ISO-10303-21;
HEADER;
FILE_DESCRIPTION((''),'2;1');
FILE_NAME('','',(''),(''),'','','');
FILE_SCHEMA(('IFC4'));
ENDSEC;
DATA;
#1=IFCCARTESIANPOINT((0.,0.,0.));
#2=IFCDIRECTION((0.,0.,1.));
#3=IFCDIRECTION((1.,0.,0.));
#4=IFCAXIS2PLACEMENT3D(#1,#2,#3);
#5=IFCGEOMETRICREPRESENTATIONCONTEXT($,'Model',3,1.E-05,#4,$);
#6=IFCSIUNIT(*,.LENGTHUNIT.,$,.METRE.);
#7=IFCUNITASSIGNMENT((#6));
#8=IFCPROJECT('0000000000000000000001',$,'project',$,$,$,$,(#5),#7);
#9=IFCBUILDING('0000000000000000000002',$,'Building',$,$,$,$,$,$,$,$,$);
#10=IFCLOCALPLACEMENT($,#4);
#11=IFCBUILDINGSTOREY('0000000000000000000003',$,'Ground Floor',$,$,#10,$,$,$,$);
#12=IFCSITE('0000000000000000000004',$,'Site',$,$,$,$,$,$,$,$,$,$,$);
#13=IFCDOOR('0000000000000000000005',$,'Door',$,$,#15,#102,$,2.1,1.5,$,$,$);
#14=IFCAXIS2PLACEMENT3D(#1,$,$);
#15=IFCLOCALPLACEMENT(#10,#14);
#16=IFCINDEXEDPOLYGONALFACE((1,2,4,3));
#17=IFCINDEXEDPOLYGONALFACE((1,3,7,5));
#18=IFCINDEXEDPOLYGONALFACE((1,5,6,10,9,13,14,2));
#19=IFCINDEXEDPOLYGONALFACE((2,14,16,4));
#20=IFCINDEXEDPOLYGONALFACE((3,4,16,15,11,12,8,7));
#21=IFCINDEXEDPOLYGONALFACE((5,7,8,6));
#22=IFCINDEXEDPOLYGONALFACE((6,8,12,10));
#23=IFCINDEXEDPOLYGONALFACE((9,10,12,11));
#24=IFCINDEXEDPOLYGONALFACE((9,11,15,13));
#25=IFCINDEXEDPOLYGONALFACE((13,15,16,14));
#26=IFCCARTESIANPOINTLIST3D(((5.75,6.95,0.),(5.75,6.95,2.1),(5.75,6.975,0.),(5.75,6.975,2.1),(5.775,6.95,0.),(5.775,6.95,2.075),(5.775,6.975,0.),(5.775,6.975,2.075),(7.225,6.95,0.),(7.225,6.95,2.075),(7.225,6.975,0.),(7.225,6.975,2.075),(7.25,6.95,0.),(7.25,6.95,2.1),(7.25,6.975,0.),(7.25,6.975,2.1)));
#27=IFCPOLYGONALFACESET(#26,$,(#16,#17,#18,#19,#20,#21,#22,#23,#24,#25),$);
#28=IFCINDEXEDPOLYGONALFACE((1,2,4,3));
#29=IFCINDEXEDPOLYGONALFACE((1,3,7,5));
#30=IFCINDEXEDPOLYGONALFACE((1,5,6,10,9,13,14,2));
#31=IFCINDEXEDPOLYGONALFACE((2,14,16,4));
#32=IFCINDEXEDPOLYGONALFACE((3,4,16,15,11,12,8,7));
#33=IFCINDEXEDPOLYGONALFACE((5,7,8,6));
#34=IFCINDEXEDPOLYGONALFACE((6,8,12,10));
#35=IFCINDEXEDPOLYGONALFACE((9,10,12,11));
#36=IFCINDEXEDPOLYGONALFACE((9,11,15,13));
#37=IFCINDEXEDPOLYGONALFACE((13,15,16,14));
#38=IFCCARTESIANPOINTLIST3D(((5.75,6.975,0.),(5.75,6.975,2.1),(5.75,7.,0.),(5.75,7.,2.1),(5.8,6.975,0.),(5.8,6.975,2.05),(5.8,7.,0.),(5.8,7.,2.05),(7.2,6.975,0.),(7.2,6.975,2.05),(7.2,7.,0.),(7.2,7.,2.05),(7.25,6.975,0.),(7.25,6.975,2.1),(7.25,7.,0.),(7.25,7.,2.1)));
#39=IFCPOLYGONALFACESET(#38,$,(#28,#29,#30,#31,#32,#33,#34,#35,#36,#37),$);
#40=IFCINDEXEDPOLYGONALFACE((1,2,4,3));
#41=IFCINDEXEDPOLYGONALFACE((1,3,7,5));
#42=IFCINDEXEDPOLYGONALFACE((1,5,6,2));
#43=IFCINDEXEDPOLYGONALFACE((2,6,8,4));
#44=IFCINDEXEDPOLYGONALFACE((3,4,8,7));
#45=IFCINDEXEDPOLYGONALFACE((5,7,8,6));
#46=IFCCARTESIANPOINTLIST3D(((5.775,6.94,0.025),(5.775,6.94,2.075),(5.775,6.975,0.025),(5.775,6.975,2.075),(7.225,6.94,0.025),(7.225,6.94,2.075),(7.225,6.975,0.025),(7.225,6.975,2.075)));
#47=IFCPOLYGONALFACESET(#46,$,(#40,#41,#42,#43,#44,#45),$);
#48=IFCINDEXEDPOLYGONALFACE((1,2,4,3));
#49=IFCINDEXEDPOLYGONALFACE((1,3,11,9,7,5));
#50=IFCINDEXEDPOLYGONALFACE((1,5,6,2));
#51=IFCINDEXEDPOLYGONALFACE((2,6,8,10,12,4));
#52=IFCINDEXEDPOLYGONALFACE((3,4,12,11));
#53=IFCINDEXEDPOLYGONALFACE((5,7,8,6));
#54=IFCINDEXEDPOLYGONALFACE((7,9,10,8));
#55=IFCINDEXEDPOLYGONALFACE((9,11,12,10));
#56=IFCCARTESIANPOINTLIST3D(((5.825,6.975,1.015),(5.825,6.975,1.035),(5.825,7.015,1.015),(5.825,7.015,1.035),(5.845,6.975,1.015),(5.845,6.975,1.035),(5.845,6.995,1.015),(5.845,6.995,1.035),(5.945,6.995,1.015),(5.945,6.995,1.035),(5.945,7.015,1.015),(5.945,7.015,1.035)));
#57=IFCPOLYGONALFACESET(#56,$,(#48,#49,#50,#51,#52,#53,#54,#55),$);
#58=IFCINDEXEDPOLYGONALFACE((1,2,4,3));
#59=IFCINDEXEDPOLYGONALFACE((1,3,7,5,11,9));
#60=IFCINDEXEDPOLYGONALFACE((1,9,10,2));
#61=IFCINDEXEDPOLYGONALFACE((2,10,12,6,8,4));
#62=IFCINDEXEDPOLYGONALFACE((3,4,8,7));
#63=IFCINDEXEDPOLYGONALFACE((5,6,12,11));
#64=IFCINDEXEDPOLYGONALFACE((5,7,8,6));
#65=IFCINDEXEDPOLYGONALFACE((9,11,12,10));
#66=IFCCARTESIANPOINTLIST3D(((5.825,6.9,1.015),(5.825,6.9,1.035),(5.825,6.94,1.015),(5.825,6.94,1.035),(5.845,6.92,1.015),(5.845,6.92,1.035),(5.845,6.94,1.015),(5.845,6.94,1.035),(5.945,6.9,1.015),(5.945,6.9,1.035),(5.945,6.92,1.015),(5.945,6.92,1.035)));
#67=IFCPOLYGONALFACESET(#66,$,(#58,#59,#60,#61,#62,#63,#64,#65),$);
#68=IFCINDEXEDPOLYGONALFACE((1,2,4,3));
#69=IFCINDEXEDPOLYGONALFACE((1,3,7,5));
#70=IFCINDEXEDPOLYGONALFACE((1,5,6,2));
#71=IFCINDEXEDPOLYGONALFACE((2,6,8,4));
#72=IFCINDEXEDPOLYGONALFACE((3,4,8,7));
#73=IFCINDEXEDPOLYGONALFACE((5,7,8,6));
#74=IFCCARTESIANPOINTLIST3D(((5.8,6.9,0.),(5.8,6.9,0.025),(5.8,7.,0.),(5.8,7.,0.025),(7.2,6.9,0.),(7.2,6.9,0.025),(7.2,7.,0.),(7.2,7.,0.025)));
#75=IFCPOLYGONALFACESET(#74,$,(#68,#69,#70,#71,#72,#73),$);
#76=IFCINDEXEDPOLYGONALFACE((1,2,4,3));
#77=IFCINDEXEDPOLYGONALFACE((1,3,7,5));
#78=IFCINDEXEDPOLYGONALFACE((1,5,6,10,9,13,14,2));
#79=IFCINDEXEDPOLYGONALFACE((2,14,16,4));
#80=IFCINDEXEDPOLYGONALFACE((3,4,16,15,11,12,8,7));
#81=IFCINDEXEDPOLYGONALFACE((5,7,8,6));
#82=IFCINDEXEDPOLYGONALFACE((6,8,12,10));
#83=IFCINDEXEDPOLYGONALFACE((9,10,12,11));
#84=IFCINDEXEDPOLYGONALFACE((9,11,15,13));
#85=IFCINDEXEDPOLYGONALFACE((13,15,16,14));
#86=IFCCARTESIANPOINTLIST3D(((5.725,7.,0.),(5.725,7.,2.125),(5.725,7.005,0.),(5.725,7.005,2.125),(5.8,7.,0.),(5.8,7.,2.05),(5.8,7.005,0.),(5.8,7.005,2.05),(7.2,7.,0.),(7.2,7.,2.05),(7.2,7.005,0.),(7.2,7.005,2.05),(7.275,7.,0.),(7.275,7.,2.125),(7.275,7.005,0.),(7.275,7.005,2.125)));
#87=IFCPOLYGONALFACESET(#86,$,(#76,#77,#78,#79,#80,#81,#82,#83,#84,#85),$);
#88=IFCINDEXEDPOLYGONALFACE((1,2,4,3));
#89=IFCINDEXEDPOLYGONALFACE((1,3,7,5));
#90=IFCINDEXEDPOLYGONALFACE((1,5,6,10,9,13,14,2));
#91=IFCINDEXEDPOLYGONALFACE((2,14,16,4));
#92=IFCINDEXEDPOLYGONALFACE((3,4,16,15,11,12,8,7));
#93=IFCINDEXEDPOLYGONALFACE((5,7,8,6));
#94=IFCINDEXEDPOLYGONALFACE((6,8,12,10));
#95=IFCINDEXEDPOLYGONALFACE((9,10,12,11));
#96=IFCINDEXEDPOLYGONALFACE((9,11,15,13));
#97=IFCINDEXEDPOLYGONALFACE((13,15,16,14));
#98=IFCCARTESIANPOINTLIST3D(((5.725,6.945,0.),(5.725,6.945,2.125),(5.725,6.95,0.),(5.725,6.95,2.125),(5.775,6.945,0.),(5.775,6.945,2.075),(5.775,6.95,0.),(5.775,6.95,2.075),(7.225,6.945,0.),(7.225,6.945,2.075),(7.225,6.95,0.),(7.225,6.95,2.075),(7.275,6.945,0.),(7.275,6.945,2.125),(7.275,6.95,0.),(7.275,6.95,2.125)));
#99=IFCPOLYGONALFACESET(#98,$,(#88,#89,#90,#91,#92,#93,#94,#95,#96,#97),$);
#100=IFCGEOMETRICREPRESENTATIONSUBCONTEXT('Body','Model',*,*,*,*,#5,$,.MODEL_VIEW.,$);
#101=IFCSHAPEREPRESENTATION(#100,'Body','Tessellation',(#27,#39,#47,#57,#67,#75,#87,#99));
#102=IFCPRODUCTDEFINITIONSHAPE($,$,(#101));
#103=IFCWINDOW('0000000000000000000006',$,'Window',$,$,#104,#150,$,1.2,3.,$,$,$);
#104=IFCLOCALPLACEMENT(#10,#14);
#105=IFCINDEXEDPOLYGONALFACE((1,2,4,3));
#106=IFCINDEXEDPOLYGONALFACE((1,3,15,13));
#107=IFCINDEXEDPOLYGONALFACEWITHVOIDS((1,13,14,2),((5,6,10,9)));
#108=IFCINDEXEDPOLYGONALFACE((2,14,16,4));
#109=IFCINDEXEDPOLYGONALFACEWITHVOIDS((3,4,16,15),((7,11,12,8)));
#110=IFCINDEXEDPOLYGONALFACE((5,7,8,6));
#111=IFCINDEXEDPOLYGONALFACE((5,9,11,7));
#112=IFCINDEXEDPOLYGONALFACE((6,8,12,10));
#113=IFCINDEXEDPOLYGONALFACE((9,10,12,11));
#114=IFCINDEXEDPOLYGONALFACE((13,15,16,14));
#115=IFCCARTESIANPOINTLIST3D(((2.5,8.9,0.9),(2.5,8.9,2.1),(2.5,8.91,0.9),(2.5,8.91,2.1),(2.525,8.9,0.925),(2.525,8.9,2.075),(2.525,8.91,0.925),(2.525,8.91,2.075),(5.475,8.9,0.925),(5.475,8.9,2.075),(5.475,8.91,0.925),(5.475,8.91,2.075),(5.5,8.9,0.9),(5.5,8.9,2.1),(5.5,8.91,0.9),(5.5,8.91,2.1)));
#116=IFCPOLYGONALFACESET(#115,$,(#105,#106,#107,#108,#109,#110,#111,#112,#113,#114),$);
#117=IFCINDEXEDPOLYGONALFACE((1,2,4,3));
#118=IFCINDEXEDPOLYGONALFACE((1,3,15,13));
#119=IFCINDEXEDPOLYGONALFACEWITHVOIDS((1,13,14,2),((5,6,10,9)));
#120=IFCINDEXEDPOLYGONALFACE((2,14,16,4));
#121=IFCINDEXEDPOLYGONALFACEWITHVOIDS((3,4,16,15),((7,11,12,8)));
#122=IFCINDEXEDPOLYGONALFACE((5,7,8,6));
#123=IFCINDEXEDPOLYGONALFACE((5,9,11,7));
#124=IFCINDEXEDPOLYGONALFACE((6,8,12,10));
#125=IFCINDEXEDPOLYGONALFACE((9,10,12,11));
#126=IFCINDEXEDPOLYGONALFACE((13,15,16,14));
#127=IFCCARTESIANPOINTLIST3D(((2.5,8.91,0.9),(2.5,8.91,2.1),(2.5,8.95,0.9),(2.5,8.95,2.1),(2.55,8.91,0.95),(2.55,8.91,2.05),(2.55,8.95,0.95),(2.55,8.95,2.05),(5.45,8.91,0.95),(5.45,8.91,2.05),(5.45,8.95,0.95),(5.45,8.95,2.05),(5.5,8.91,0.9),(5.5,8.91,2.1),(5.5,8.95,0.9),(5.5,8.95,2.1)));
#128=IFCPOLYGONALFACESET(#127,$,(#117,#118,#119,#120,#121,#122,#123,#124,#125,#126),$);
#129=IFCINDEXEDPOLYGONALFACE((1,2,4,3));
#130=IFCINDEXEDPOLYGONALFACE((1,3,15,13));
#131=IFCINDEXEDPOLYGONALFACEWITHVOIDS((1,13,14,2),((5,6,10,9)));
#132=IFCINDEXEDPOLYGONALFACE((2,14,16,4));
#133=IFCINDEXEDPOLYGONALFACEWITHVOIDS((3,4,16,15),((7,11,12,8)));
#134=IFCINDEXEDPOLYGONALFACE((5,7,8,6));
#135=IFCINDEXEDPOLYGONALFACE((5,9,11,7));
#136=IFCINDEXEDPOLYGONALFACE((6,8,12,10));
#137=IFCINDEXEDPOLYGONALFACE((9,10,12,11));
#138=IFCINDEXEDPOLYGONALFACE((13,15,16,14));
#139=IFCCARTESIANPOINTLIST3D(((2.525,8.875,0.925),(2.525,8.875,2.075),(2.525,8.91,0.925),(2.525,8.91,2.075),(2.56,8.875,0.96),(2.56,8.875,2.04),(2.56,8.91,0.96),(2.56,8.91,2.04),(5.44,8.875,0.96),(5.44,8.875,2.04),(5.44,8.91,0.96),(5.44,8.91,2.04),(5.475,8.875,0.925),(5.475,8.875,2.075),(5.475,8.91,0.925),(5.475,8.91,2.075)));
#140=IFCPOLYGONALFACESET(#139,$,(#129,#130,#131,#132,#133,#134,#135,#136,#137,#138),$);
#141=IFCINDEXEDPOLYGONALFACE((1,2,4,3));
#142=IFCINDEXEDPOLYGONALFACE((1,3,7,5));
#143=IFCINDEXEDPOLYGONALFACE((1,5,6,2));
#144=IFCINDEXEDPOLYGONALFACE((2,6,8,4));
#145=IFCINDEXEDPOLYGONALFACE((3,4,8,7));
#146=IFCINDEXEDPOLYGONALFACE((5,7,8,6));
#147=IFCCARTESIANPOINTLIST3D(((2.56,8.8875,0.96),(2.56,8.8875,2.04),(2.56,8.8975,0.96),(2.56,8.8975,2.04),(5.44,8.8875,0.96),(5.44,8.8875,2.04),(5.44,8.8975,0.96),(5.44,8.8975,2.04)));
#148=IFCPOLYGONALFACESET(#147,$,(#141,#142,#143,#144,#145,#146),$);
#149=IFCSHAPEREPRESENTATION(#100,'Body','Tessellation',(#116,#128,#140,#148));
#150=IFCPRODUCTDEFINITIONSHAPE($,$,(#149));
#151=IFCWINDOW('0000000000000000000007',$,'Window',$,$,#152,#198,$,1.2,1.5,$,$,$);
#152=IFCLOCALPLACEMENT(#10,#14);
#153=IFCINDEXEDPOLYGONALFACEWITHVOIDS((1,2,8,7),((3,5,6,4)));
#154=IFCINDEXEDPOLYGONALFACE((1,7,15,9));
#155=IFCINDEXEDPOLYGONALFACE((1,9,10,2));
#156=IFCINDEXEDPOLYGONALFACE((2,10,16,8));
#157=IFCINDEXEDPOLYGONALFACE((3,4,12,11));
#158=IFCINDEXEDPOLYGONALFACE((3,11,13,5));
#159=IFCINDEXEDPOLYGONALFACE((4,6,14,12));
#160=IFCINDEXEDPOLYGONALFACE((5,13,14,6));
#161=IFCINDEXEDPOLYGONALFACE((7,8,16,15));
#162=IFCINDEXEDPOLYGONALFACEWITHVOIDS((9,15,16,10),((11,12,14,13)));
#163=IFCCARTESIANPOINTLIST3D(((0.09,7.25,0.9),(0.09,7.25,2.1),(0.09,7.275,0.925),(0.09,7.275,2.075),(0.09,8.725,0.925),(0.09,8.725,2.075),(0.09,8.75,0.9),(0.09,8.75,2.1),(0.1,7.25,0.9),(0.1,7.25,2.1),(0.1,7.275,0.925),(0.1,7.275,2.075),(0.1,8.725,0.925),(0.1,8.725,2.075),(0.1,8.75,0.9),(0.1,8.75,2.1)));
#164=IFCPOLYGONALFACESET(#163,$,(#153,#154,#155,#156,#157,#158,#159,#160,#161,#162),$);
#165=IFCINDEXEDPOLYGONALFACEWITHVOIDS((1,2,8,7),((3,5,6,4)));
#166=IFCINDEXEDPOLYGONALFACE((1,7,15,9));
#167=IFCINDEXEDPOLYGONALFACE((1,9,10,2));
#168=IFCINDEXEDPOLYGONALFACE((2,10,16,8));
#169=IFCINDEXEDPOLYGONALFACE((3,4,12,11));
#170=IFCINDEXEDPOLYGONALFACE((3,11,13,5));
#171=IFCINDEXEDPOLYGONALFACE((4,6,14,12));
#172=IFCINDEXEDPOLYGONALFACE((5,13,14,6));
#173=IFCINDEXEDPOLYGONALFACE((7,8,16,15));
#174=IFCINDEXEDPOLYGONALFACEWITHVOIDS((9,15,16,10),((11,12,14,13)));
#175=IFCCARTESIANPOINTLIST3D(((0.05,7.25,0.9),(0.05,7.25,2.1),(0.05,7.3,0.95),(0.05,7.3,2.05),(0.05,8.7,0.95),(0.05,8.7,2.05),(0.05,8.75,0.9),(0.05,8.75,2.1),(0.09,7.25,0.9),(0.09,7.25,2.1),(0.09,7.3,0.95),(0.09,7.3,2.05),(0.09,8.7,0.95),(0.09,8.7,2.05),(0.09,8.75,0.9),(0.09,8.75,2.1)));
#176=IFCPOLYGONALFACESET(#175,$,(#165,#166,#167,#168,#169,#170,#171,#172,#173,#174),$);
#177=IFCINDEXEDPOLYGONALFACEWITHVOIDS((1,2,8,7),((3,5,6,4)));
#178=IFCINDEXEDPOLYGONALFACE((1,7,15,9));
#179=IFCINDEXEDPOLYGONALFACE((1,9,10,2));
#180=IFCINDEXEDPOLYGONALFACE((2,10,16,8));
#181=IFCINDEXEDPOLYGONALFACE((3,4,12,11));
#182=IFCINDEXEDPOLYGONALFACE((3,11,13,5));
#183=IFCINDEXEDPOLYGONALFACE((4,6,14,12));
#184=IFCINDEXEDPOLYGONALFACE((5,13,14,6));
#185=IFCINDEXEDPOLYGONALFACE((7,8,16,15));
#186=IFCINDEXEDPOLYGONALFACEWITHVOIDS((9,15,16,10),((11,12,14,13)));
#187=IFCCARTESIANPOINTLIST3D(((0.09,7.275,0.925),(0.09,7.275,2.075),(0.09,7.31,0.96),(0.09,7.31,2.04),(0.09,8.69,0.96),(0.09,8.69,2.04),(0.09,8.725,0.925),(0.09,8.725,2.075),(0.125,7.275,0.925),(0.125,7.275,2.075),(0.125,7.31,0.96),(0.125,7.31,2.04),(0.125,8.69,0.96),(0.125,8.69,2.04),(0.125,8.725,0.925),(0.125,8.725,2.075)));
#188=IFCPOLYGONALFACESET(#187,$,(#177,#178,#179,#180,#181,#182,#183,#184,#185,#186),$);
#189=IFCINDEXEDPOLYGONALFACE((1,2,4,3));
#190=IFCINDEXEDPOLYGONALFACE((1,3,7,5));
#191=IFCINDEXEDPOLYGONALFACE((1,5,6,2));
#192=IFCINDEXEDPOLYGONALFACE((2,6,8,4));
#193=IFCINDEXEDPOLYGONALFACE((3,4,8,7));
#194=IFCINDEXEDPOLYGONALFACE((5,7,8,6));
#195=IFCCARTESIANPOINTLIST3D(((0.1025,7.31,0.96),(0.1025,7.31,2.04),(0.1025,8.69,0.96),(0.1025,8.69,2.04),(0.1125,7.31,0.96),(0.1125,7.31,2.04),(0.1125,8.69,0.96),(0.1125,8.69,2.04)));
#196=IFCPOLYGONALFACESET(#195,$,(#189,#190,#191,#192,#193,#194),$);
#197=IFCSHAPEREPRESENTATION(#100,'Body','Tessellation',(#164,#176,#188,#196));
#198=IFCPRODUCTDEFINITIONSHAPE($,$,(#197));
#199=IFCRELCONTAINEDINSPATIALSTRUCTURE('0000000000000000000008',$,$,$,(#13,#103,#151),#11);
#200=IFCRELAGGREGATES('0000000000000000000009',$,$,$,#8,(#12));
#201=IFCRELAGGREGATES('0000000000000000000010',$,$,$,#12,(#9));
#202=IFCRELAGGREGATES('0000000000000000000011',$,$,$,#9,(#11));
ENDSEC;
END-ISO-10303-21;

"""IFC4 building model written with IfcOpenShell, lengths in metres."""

from ifc_helpers import new_model, si_unit, frame, origin_with_axes, place, context, subcontext, project, spatial, line, indexed_curve, outline, extrude, element, save


model = new_model("IFC4")

# Units and contexts
model_context = context("Model", 3, precision=1e-05, world=origin_with_axes())
body_context = subcontext(model_context, "Body", "Model", "MODEL_VIEW")
ifc_project = project(units=[si_unit("LENGTHUNIT", "METRE")], contexts=[model_context])

# Site, building, storey
site = spatial("IfcSite", under=ifc_project, Name="Site")
building = spatial("IfcBuilding", under=site, Name="Building")
storey_placement = place(None, origin_with_axes())
storey = spatial("IfcBuildingStorey", under=building, at=storey_placement, Name="Ground Floor")

# Door
door_1_placement = place(storey_placement, frame((7.25, 7.0, 0.0), z_axis=(0.0, 0.0, 1.0), x_axis=(-1.0, 0.0, 0.0)))
element("IfcDoor", 1, at=door_1_placement, inside=storey, Name="Door", OverallHeight=2.1, OverallWidth=1.5, context=body_context, shape_type="SweptSolid", body=[
    extrude(outline(indexed_curve([(0.0, 0.0), (0.0, 2.1), (1.5, 2.1), (1.5, 0.0), (1.475, 0.0), (1.475, 2.075), (0.025, 2.075), (0.025, 0.0)], segments=[line(1, 2, 3, 4, 5, 6, 7, 8, 1)])), frame((0.0, 0.025, 0.0), z_axis=(0.0, -1.0, 0.0), x_axis=(1.0, 0.0, 0.0)), (0.0, 0.0, -1.0), 0.025),
    extrude(outline(indexed_curve([(0.0, 0.0), (0.0, 2.1), (1.5, 2.1), (1.5, 0.0), (1.45, 0.0), (1.45, 2.05), (0.05, 2.05), (0.05, 0.0)], segments=[line(1, 2, 3, 4, 5, 6, 7, 8, 1)])), frame((0.0, 0.0, 0.0), z_axis=(0.0, -1.0, 0.0), x_axis=(1.0, 0.0, 0.0)), (0.0, 0.0, -1.0), 0.025),
    extrude(outline(indexed_curve([(0.0, 0.0), (1.45, 0.0), (1.45, 0.035), (0.0, 0.035)], segments=[line(1, 2, 3, 4, 1)])), frame((0.025, 0.025, 0.025), z_axis=(0.0, 0.0, 1.0), x_axis=(1.0, 0.0, 0.0)), (0.0, 0.0, 1.0), 2.05),
    extrude(outline(indexed_curve([(0.0, 0.0), (0.0, -0.04), (-0.12, -0.04), (-0.12, -0.02), (-0.02, -0.02), (-0.02, 0.0)], segments=[line(1, 2, 3, 4, 5, 6, 1)])), frame((1.425, 0.025, 1.015), z_axis=(0.0, 0.0, 1.0), x_axis=(1.0, 0.0, 0.0)), (0.0, 0.0, 1.0), 0.02),
    extrude(outline(indexed_curve([(0.0, 0.0), (0.0, 0.04), (-0.12, 0.04), (-0.12, 0.02), (-0.02, 0.02), (-0.02, 0.0)], segments=[line(1, 2, 3, 4, 5, 6, 1)])), frame((1.425, 0.06, 1.015), z_axis=(0.0, 0.0, 1.0), x_axis=(1.0, 0.0, 0.0)), (0.0, 0.0, 1.0), 0.02),
    extrude(outline(indexed_curve([(0.0, 0.0), (1.4, 0.0), (1.4, 0.1), (0.0, 0.1)], segments=[line(1, 2, 3, 4, 1)])), frame((0.05, 0.0, 0.0), z_axis=(0.0, 0.0, 1.0), x_axis=(1.0, 0.0, 0.0)), (0.0, 0.0, 1.0), 0.025),
    extrude(outline(indexed_curve([(0.0, 0.0), (0.0, 2.125), (1.55, 2.125), (1.55, 0.0), (1.475, 0.0), (1.475, 2.05), (0.075, 2.05), (0.075, 0.0)], segments=[line(1, 2, 3, 4, 5, 6, 7, 8, 1)])), frame((-0.025, -0.005, 0.0), z_axis=(0.0, -1.0, 0.0), x_axis=(1.0, 0.0, 0.0)), (0.0, 0.0, -1.0), 0.005),
    extrude(outline(indexed_curve([(0.0, 0.0), (0.0, 2.125), (1.55, 2.125), (1.55, 0.0), (1.5, 0.0), (1.5, 2.075), (0.05, 2.075), (0.05, 0.0)], segments=[line(1, 2, 3, 4, 5, 6, 7, 8, 1)])), frame((-0.025, 0.05, 0.0), z_axis=(0.0, -1.0, 0.0), x_axis=(1.0, 0.0, 0.0)), (0.0, 0.0, -1.0), 0.005),
])

# Windows
window_1_placement = place(storey_placement, frame((5.5, 9.0, 0.9), z_axis=(0.0, 0.0, 1.0), x_axis=(-1.0, 0.0, 0.0)))
element("IfcWindow", 2, at=window_1_placement, inside=storey, Name="Window", OverallHeight=1.2, OverallWidth=3.0, context=body_context, shape_type="SweptSolid", body=[
    extrude(outline(indexed_curve([(0.0, 0.0), (3.0, 0.0), (3.0, 1.2), (0.0, 1.2)], segments=[line(1, 2, 3, 4, 1)]), holes=[indexed_curve([(0.025, 0.025), (2.975, 0.025), (2.975, 1.175), (0.025, 1.175)], segments=[line(1, 2, 3, 4, 1)])]), frame((0.0, 0.09, 0.0), z_axis=(0.0, -1.0, 0.0), x_axis=(1.0, 0.0, 0.0)), (0.0, 0.0, -1.0), 0.01),
    extrude(outline(indexed_curve([(0.0, 0.0), (3.0, 0.0), (3.0, 1.2), (0.0, 1.2)], segments=[line(1, 2, 3, 4, 1)]), holes=[indexed_curve([(0.05, 0.05), (2.95, 0.05), (2.95, 1.15), (0.05, 1.15)], segments=[line(1, 2, 3, 4, 1)])]), frame((0.0, 0.05, 0.0), z_axis=(0.0, -1.0, 0.0), x_axis=(1.0, 0.0, 0.0)), (0.0, 0.0, -1.0), 0.04),
    extrude(outline(indexed_curve([(0.0, 0.0), (2.95, 0.0), (2.95, 1.15), (0.0, 1.15)], segments=[line(1, 2, 3, 4, 1)]), holes=[indexed_curve([(0.035, 0.035), (2.915, 0.035), (2.915, 1.115), (0.035, 1.115)], segments=[line(1, 2, 3, 4, 1)])]), frame((0.025, 0.09, 0.025), z_axis=(0.0, -1.0, 0.0), x_axis=(1.0, 0.0, 0.0)), (0.0, 0.0, -1.0), 0.035),
    extrude(outline(indexed_curve([(0.035, 0.035), (2.915, 0.035), (2.915, 1.115), (0.035, 1.115)], segments=[line(1, 2, 3, 4, 1)])), frame((0.025, 0.1025, 0.025), z_axis=(0.0, -1.0, 0.0), x_axis=(1.0, 0.0, 0.0)), (0.0, 0.0, -1.0), 0.01),
])
for number, where, z_axis, x_axis, name in (
    (3, (0.0, 8.75, 0.9), (0.0, 0.0, 1.0), (0.0, -1.0, 0.0), "Window"),
):
    element("IfcWindow", number, at=place(storey_placement, frame(where, z_axis=z_axis, x_axis=x_axis)), inside=storey, Name=name, OverallHeight=1.2, OverallWidth=1.5, context=body_context, shape_type="SweptSolid", body=[
        extrude(outline(indexed_curve([(0.0, 0.0), (1.5, 0.0), (1.5, 1.2), (0.0, 1.2)], segments=[line(1, 2, 3, 4, 1)]), holes=[indexed_curve([(0.025, 0.025), (1.475, 0.025), (1.475, 1.175), (0.025, 1.175)], segments=[line(1, 2, 3, 4, 1)])]), frame((0.0, 0.09, 0.0), z_axis=(0.0, -1.0, 0.0), x_axis=(1.0, 0.0, 0.0)), (0.0, 0.0, -1.0), 0.01),
        extrude(outline(indexed_curve([(0.0, 0.0), (1.5, 0.0), (1.5, 1.2), (0.0, 1.2)], segments=[line(1, 2, 3, 4, 1)]), holes=[indexed_curve([(0.05, 0.05), (1.45, 0.05), (1.45, 1.15), (0.05, 1.15)], segments=[line(1, 2, 3, 4, 1)])]), frame((0.0, 0.05, 0.0), z_axis=(0.0, -1.0, 0.0), x_axis=(1.0, 0.0, 0.0)), (0.0, 0.0, -1.0), 0.04),
        extrude(outline(indexed_curve([(0.0, 0.0), (1.45, 0.0), (1.45, 1.15), (0.0, 1.15)], segments=[line(1, 2, 3, 4, 1)]), holes=[indexed_curve([(0.035, 0.035), (1.415, 0.035), (1.415, 1.115), (0.035, 1.115)], segments=[line(1, 2, 3, 4, 1)])]), frame((0.025, 0.09, 0.025), z_axis=(0.0, -1.0, 0.0), x_axis=(1.0, 0.0, 0.0)), (0.0, 0.0, -1.0), 0.035),
        extrude(outline(indexed_curve([(0.035, 0.035), (1.415, 0.035), (1.415, 1.115), (0.035, 1.115)], segments=[line(1, 2, 3, 4, 1)])), frame((0.025, 0.1025, 0.025), z_axis=(0.0, -1.0, 0.0), x_axis=(1.0, 0.0, 0.0)), (0.0, 0.0, -1.0), 0.01),
    ])

save(model, "model.ifc")
